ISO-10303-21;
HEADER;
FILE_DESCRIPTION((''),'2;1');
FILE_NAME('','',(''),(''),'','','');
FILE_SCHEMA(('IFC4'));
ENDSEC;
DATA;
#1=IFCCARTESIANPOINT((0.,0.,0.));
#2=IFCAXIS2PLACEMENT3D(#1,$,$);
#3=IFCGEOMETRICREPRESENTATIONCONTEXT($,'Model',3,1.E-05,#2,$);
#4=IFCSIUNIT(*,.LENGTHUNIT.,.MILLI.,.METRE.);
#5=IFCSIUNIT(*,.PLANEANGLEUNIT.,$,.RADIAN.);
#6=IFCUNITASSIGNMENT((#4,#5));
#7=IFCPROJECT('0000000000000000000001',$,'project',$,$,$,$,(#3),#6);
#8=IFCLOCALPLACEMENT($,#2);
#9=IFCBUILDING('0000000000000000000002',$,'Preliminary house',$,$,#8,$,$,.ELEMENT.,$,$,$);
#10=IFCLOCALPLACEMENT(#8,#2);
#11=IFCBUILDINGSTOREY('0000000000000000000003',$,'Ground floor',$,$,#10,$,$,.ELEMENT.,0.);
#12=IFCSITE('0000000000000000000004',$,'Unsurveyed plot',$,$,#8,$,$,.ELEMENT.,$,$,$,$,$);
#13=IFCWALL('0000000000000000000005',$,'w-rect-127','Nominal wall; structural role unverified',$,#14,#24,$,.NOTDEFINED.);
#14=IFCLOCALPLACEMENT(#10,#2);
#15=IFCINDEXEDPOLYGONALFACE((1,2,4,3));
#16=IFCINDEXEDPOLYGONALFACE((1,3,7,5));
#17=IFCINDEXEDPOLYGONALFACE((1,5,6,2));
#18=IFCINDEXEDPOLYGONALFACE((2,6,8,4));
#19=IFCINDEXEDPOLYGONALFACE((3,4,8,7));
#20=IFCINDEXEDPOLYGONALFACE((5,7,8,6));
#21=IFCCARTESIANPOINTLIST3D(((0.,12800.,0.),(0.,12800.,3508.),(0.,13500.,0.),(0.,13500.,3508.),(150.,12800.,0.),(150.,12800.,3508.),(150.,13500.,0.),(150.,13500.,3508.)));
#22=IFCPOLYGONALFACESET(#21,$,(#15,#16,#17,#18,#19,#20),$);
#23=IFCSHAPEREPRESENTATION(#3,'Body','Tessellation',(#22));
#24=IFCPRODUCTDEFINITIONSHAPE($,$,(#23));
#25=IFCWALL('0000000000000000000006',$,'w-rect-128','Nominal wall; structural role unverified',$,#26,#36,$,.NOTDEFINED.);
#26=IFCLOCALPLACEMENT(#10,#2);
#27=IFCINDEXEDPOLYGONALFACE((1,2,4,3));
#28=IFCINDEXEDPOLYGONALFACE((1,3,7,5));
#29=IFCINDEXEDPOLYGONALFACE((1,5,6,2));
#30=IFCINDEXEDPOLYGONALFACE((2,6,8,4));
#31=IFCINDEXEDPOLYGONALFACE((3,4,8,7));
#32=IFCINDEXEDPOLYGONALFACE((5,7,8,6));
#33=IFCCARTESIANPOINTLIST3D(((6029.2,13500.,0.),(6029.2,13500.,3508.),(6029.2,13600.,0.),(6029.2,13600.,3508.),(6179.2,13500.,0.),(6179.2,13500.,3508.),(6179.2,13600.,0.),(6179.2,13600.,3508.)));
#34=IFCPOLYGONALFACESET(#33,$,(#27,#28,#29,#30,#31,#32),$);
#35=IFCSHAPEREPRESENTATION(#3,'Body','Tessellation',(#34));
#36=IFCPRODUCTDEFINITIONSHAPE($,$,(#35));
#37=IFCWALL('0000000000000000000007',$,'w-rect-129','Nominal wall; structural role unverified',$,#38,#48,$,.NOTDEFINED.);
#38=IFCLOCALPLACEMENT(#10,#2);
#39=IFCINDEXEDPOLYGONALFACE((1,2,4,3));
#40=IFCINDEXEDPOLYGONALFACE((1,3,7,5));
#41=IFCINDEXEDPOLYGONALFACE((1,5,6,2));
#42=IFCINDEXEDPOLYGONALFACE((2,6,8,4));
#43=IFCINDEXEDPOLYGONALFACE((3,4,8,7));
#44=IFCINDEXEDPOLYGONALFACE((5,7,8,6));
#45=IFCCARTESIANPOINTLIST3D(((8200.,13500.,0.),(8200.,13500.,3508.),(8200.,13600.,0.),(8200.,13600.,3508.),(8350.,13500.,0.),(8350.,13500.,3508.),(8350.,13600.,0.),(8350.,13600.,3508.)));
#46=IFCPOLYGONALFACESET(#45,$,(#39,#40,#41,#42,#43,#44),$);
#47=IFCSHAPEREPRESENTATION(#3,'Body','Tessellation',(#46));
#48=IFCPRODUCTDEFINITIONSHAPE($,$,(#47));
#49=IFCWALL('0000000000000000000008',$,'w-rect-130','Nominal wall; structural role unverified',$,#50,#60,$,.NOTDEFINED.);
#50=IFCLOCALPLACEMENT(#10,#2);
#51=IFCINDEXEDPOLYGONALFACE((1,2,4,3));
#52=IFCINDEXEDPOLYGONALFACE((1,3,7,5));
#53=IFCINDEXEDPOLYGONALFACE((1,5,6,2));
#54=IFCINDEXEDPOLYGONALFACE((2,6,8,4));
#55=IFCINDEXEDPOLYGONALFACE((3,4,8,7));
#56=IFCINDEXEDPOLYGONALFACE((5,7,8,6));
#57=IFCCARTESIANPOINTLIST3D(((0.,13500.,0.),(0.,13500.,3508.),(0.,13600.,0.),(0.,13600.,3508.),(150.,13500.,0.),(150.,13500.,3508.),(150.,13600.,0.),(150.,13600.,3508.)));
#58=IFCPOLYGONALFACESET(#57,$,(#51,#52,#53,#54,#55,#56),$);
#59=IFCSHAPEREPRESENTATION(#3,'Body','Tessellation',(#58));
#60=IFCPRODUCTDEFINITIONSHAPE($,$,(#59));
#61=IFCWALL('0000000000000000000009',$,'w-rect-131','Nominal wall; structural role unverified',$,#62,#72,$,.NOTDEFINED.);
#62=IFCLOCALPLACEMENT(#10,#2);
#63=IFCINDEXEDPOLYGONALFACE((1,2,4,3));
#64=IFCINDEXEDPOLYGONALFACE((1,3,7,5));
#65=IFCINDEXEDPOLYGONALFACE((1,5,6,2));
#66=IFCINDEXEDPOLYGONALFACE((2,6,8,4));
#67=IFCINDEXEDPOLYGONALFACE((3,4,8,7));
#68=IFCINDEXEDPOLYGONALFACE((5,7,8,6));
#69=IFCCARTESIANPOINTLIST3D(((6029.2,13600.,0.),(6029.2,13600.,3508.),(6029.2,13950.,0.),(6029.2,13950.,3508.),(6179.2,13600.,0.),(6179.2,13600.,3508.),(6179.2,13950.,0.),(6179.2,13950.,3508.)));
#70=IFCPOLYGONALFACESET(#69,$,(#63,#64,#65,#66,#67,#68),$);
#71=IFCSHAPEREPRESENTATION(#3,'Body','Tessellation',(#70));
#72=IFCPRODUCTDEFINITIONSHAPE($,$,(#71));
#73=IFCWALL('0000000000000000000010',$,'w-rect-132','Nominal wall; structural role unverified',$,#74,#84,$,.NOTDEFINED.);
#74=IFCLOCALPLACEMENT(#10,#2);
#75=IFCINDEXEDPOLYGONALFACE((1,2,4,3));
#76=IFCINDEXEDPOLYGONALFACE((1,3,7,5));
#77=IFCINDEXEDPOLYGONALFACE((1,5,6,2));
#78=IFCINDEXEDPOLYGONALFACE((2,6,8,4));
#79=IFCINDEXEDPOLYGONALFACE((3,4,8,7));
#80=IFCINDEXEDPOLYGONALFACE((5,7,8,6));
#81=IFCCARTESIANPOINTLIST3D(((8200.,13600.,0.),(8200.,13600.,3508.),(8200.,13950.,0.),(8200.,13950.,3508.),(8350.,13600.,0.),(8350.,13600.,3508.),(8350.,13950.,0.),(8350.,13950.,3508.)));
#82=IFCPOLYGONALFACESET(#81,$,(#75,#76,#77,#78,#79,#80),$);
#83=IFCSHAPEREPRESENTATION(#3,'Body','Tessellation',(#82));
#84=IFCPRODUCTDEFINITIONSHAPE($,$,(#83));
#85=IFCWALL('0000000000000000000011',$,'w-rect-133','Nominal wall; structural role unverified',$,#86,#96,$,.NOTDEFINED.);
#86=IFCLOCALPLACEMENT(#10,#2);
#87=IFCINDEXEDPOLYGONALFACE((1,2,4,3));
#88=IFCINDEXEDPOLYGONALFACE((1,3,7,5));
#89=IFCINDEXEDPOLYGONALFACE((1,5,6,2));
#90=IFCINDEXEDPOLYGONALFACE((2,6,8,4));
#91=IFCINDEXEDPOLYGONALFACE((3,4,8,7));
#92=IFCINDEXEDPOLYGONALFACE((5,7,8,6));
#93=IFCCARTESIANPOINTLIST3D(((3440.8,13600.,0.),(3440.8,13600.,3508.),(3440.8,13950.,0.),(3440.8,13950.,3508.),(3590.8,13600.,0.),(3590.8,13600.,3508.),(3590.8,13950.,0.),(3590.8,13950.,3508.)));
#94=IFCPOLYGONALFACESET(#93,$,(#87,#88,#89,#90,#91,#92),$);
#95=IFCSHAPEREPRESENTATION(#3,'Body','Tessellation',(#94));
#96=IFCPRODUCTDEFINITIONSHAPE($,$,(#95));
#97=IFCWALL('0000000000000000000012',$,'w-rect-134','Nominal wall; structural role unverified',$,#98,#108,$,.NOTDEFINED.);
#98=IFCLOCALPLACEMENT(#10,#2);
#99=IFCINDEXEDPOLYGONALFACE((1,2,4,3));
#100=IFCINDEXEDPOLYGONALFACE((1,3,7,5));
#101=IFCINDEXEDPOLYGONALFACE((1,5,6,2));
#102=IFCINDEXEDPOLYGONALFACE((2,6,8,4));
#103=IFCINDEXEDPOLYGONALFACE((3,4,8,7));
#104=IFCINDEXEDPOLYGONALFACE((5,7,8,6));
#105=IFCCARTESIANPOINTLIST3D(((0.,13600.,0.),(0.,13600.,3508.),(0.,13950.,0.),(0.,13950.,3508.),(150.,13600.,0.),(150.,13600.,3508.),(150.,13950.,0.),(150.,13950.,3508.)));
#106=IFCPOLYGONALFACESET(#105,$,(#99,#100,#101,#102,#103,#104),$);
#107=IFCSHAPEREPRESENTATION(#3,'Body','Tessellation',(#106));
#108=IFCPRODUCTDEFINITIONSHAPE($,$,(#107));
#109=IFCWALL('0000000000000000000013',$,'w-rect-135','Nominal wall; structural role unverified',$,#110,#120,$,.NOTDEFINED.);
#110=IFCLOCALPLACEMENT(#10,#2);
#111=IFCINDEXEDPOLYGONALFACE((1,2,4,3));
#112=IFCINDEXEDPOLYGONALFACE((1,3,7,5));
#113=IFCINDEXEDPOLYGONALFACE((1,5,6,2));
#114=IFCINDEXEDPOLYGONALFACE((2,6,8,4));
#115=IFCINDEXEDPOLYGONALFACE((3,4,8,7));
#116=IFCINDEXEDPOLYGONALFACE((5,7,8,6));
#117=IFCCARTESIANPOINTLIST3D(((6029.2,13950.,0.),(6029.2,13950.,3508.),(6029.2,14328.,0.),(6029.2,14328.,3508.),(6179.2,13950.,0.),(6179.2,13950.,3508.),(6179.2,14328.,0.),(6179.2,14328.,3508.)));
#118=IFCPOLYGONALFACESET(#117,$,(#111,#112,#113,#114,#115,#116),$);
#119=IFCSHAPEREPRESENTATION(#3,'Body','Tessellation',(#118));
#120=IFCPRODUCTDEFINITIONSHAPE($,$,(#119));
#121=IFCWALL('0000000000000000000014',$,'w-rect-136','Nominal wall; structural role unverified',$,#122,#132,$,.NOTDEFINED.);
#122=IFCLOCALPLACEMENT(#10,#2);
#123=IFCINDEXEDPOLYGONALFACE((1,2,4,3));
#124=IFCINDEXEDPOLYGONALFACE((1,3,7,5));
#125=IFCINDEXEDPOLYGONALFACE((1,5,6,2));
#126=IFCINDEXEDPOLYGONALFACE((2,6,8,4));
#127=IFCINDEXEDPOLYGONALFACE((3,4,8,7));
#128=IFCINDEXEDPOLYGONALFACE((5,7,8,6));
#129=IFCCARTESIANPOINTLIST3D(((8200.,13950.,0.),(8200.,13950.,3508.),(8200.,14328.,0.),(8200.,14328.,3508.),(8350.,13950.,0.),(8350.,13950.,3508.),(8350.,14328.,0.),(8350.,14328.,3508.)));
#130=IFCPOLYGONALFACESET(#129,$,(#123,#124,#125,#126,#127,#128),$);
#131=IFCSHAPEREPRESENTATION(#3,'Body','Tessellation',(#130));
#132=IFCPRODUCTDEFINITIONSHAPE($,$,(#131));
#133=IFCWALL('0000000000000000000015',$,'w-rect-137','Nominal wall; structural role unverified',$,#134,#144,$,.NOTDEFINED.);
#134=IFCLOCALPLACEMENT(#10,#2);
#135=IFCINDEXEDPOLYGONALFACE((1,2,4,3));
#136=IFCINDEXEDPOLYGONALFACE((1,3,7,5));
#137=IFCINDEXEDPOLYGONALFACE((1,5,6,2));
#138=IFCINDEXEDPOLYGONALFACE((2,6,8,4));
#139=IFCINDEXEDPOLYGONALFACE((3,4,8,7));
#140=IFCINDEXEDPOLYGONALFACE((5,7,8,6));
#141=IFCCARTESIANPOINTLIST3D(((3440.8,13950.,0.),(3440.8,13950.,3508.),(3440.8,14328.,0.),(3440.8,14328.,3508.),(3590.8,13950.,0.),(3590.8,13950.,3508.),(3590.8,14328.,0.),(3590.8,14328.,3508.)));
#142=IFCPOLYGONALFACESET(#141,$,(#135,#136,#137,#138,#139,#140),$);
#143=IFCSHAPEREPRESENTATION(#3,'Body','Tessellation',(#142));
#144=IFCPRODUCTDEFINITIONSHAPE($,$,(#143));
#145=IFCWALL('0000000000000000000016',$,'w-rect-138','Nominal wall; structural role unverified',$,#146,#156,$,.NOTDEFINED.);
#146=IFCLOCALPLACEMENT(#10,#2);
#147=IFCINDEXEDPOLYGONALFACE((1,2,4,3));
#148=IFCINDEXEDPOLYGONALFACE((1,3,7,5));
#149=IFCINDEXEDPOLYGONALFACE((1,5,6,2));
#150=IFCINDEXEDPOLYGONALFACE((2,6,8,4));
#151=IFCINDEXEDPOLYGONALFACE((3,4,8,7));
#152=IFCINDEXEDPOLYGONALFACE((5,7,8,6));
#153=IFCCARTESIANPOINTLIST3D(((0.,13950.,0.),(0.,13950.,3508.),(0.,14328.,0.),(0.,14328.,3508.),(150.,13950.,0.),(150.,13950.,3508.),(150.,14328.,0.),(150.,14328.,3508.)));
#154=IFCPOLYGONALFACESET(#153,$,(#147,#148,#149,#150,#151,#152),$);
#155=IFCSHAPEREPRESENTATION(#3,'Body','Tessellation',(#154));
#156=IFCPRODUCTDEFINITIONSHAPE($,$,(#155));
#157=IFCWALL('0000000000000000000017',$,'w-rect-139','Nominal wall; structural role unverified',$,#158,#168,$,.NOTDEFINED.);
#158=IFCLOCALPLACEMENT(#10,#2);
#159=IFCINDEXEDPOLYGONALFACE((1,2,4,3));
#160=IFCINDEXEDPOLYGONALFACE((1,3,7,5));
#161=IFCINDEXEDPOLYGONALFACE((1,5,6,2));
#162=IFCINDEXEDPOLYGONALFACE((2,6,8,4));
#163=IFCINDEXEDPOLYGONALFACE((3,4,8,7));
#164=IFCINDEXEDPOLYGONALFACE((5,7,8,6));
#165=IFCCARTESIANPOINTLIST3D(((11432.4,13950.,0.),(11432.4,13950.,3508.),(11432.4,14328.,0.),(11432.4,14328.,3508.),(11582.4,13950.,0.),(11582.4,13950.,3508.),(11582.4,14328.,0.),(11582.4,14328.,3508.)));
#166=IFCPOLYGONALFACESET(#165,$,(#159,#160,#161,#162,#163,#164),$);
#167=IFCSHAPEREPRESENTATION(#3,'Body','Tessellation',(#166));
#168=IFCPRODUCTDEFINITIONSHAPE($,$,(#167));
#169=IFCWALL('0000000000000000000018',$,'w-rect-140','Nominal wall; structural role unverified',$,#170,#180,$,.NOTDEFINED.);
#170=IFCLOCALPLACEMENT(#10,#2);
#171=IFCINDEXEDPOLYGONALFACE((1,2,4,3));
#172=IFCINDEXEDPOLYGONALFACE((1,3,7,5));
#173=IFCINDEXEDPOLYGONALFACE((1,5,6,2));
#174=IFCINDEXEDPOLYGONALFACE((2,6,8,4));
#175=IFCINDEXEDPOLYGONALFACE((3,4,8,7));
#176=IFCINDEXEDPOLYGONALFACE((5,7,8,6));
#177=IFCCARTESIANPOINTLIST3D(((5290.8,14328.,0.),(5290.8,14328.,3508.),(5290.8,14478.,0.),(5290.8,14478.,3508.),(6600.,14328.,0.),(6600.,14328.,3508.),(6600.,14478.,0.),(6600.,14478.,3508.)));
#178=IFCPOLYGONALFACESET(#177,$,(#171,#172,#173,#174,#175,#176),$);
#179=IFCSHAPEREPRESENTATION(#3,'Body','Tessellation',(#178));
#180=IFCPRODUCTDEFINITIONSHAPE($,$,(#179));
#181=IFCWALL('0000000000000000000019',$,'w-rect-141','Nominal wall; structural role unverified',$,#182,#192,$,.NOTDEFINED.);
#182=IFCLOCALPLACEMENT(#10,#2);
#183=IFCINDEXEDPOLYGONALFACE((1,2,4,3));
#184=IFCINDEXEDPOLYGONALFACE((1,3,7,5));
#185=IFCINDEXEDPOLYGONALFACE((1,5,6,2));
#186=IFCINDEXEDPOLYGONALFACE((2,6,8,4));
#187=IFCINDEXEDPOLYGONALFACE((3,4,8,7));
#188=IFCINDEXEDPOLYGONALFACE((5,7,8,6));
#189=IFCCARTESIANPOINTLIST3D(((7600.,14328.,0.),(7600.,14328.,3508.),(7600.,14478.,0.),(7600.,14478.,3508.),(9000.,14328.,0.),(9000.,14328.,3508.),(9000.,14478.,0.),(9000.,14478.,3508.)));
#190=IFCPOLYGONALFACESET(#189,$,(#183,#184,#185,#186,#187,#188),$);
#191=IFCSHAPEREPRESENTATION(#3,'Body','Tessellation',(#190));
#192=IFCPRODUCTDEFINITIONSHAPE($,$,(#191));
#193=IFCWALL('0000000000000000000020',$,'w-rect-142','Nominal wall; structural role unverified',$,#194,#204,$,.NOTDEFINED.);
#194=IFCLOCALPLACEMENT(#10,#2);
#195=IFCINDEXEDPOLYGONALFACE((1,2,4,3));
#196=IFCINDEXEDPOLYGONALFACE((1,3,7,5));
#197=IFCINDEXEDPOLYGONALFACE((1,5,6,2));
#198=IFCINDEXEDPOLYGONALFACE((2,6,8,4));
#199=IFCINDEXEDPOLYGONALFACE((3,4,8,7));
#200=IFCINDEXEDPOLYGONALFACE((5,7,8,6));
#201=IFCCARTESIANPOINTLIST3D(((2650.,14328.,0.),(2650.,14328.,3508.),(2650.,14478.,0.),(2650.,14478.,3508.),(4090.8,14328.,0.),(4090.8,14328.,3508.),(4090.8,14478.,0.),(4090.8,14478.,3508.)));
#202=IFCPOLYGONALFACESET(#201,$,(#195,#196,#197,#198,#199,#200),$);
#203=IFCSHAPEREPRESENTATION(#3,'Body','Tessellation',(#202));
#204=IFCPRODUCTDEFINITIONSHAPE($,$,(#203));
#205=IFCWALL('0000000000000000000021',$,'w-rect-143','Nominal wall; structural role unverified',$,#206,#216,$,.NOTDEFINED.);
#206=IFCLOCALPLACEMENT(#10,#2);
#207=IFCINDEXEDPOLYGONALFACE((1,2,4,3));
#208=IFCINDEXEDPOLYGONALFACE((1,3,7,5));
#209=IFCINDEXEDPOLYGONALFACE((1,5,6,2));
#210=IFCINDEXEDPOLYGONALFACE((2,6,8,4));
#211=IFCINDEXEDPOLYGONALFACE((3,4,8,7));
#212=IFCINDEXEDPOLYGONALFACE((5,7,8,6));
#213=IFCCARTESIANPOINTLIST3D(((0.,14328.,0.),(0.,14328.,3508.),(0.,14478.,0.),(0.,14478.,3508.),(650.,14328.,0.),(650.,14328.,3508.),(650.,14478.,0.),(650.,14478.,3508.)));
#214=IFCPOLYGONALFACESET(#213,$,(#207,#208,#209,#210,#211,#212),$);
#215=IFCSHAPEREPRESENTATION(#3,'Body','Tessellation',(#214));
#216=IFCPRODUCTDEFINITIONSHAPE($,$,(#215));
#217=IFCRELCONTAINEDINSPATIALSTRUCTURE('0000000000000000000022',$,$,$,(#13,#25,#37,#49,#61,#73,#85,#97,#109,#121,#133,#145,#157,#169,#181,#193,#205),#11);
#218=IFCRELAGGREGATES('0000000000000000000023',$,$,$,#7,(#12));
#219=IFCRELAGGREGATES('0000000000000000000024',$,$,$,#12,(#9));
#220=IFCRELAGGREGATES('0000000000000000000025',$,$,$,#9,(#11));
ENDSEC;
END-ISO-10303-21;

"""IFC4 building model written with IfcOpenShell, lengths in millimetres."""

from ifc_helpers import new_model, si_unit, origin, place, context, project, spatial, polyline, outline, extrude, element, save


model = new_model("IFC4")

# Units and contexts
model_context = context("Model", 3, precision=1e-05, world=origin())
ifc_project = project(units=[si_unit("LENGTHUNIT", "METRE", prefix="MILLI"), si_unit("PLANEANGLEUNIT", "RADIAN")], contexts=[model_context])

# Site, building, storey
placement_1 = place(None, origin())
site = spatial("IfcSite", under=ifc_project, at=placement_1, Name="Unsurveyed plot", CompositionType="ELEMENT")
building = spatial("IfcBuilding", under=site, at=placement_1, Name="Preliminary house", CompositionType="ELEMENT")
placement_2 = place(placement_1, origin())
storey = spatial("IfcBuildingStorey", under=building, at=placement_2, Name="Ground floor", CompositionType="ELEMENT", Elevation=0.0)

# Walls
element("IfcWall", 1, at=placement_2, inside=storey, Name="w-rect-127", Description="Nominal wall; structural role unverified", PredefinedType="NOTDEFINED", context=model_context, shape_type="SweptSolid", body=[
    extrude(outline(polyline([(0.0, 12800.0), (150.0, 12800.0), (150.0, 13500.0), (0.0, 13500.0), (0.0, 12800.0)])), origin(), (0.0, 0.0, 1.0), 3508.0),
])
element("IfcWall", 2, at=placement_2, inside=storey, Name="w-rect-128", Description="Nominal wall; structural role unverified", PredefinedType="NOTDEFINED", context=model_context, shape_type="SweptSolid", body=[
    extrude(outline(polyline([(6029.2, 13500.0), (6179.2, 13500.0), (6179.2, 13600.0), (6029.2, 13600.0), (6029.2, 13500.0)])), origin(), (0.0, 0.0, 1.0), 3508.0),
])
element("IfcWall", 3, at=placement_2, inside=storey, Name="w-rect-129", Description="Nominal wall; structural role unverified", PredefinedType="NOTDEFINED", context=model_context, shape_type="SweptSolid", body=[
    extrude(outline(polyline([(8200.0, 13500.0), (8350.0, 13500.0), (8350.0, 13600.0), (8200.0, 13600.0), (8200.0, 13500.0)])), origin(), (0.0, 0.0, 1.0), 3508.0),
])
element("IfcWall", 4, at=placement_2, inside=storey, Name="w-rect-130", Description="Nominal wall; structural role unverified", PredefinedType="NOTDEFINED", context=model_context, shape_type="SweptSolid", body=[
    extrude(outline(polyline([(0.0, 13500.0), (150.0, 13500.0), (150.0, 13600.0), (0.0, 13600.0), (0.0, 13500.0)])), origin(), (0.0, 0.0, 1.0), 3508.0),
])
element("IfcWall", 5, at=placement_2, inside=storey, Name="w-rect-131", Description="Nominal wall; structural role unverified", PredefinedType="NOTDEFINED", context=model_context, shape_type="SweptSolid", body=[
    extrude(outline(polyline([(6029.2, 13600.0), (6179.2, 13600.0), (6179.2, 13950.0), (6029.2, 13950.0), (6029.2, 13600.0)])), origin(), (0.0, 0.0, 1.0), 3508.0),
])
element("IfcWall", 6, at=placement_2, inside=storey, Name="w-rect-132", Description="Nominal wall; structural role unverified", PredefinedType="NOTDEFINED", context=model_context, shape_type="SweptSolid", body=[
    extrude(outline(polyline([(8200.0, 13600.0), (8350.0, 13600.0), (8350.0, 13950.0), (8200.0, 13950.0), (8200.0, 13600.0)])), origin(), (0.0, 0.0, 1.0), 3508.0),
])
element("IfcWall", 7, at=placement_2, inside=storey, Name="w-rect-133", Description="Nominal wall; structural role unverified", PredefinedType="NOTDEFINED", context=model_context, shape_type="SweptSolid", body=[
    extrude(outline(polyline([(3440.8, 13600.0), (3590.8, 13600.0), (3590.8, 13950.0), (3440.8, 13950.0), (3440.8, 13600.0)])), origin(), (0.0, 0.0, 1.0), 3508.0),
])
element("IfcWall", 8, at=placement_2, inside=storey, Name="w-rect-134", Description="Nominal wall; structural role unverified", PredefinedType="NOTDEFINED", context=model_context, shape_type="SweptSolid", body=[
    extrude(outline(polyline([(0.0, 13600.0), (150.0, 13600.0), (150.0, 13950.0), (0.0, 13950.0), (0.0, 13600.0)])), origin(), (0.0, 0.0, 1.0), 3508.0),
])
element("IfcWall", 9, at=placement_2, inside=storey, Name="w-rect-135", Description="Nominal wall; structural role unverified", PredefinedType="NOTDEFINED", context=model_context, shape_type="SweptSolid", body=[
    extrude(outline(polyline([(6029.2, 13950.0), (6179.2, 13950.0), (6179.2, 14328.0), (6029.2, 14328.0), (6029.2, 13950.0)])), origin(), (0.0, 0.0, 1.0), 3508.0),
])
element("IfcWall", 10, at=placement_2, inside=storey, Name="w-rect-136", Description="Nominal wall; structural role unverified", PredefinedType="NOTDEFINED", context=model_context, shape_type="SweptSolid", body=[
    extrude(outline(polyline([(8200.0, 13950.0), (8350.0, 13950.0), (8350.0, 14328.0), (8200.0, 14328.0), (8200.0, 13950.0)])), origin(), (0.0, 0.0, 1.0), 3508.0),
])
element("IfcWall", 11, at=placement_2, inside=storey, Name="w-rect-137", Description="Nominal wall; structural role unverified", PredefinedType="NOTDEFINED", context=model_context, shape_type="SweptSolid", body=[
    extrude(outline(polyline([(3440.8, 13950.0), (3590.8, 13950.0), (3590.8, 14328.0), (3440.8, 14328.0), (3440.8, 13950.0)])), origin(), (0.0, 0.0, 1.0), 3508.0),
])
element("IfcWall", 12, at=placement_2, inside=storey, Name="w-rect-138", Description="Nominal wall; structural role unverified", PredefinedType="NOTDEFINED", context=model_context, shape_type="SweptSolid", body=[
    extrude(outline(polyline([(0.0, 13950.0), (150.0, 13950.0), (150.0, 14328.0), (0.0, 14328.0), (0.0, 13950.0)])), origin(), (0.0, 0.0, 1.0), 3508.0),
])
element("IfcWall", 13, at=placement_2, inside=storey, Name="w-rect-139", Description="Nominal wall; structural role unverified", PredefinedType="NOTDEFINED", context=model_context, shape_type="SweptSolid", body=[
    extrude(outline(polyline([(11432.4, 13950.0), (11582.4, 13950.0), (11582.4, 14328.0), (11432.4, 14328.0), (11432.4, 13950.0)])), origin(), (0.0, 0.0, 1.0), 3508.0),
])
element("IfcWall", 14, at=placement_2, inside=storey, Name="w-rect-140", Description="Nominal wall; structural role unverified", PredefinedType="NOTDEFINED", context=model_context, shape_type="SweptSolid", body=[
    extrude(outline(polyline([(5290.8, 14328.0), (6600.0, 14328.0), (6600.0, 14478.0), (5290.8, 14478.0), (5290.8, 14328.0)])), origin(), (0.0, 0.0, 1.0), 3508.0),
])
element("IfcWall", 15, at=placement_2, inside=storey, Name="w-rect-141", Description="Nominal wall; structural role unverified", PredefinedType="NOTDEFINED", context=model_context, shape_type="SweptSolid", body=[
    extrude(outline(polyline([(7600.0, 14328.0), (9000.0, 14328.0), (9000.0, 14478.0), (7600.0, 14478.0), (7600.0, 14328.0)])), origin(), (0.0, 0.0, 1.0), 3508.0),
])
element("IfcWall", 16, at=placement_2, inside=storey, Name="w-rect-142", Description="Nominal wall; structural role unverified", PredefinedType="NOTDEFINED", context=model_context, shape_type="SweptSolid", body=[
    extrude(outline(polyline([(2650.0, 14328.0), (4090.8, 14328.0), (4090.8, 14478.0), (2650.0, 14478.0), (2650.0, 14328.0)])), origin(), (0.0, 0.0, 1.0), 3508.0),
])
element("IfcWall", 17, at=placement_2, inside=storey, Name="w-rect-143", Description="Nominal wall; structural role unverified", PredefinedType="NOTDEFINED", context=model_context, shape_type="SweptSolid", body=[
    extrude(outline(polyline([(0.0, 14328.0), (650.0, 14328.0), (650.0, 14478.0), (0.0, 14478.0), (0.0, 14328.0)])), origin(), (0.0, 0.0, 1.0), 3508.0),
])

save(model, "model.ifc")
